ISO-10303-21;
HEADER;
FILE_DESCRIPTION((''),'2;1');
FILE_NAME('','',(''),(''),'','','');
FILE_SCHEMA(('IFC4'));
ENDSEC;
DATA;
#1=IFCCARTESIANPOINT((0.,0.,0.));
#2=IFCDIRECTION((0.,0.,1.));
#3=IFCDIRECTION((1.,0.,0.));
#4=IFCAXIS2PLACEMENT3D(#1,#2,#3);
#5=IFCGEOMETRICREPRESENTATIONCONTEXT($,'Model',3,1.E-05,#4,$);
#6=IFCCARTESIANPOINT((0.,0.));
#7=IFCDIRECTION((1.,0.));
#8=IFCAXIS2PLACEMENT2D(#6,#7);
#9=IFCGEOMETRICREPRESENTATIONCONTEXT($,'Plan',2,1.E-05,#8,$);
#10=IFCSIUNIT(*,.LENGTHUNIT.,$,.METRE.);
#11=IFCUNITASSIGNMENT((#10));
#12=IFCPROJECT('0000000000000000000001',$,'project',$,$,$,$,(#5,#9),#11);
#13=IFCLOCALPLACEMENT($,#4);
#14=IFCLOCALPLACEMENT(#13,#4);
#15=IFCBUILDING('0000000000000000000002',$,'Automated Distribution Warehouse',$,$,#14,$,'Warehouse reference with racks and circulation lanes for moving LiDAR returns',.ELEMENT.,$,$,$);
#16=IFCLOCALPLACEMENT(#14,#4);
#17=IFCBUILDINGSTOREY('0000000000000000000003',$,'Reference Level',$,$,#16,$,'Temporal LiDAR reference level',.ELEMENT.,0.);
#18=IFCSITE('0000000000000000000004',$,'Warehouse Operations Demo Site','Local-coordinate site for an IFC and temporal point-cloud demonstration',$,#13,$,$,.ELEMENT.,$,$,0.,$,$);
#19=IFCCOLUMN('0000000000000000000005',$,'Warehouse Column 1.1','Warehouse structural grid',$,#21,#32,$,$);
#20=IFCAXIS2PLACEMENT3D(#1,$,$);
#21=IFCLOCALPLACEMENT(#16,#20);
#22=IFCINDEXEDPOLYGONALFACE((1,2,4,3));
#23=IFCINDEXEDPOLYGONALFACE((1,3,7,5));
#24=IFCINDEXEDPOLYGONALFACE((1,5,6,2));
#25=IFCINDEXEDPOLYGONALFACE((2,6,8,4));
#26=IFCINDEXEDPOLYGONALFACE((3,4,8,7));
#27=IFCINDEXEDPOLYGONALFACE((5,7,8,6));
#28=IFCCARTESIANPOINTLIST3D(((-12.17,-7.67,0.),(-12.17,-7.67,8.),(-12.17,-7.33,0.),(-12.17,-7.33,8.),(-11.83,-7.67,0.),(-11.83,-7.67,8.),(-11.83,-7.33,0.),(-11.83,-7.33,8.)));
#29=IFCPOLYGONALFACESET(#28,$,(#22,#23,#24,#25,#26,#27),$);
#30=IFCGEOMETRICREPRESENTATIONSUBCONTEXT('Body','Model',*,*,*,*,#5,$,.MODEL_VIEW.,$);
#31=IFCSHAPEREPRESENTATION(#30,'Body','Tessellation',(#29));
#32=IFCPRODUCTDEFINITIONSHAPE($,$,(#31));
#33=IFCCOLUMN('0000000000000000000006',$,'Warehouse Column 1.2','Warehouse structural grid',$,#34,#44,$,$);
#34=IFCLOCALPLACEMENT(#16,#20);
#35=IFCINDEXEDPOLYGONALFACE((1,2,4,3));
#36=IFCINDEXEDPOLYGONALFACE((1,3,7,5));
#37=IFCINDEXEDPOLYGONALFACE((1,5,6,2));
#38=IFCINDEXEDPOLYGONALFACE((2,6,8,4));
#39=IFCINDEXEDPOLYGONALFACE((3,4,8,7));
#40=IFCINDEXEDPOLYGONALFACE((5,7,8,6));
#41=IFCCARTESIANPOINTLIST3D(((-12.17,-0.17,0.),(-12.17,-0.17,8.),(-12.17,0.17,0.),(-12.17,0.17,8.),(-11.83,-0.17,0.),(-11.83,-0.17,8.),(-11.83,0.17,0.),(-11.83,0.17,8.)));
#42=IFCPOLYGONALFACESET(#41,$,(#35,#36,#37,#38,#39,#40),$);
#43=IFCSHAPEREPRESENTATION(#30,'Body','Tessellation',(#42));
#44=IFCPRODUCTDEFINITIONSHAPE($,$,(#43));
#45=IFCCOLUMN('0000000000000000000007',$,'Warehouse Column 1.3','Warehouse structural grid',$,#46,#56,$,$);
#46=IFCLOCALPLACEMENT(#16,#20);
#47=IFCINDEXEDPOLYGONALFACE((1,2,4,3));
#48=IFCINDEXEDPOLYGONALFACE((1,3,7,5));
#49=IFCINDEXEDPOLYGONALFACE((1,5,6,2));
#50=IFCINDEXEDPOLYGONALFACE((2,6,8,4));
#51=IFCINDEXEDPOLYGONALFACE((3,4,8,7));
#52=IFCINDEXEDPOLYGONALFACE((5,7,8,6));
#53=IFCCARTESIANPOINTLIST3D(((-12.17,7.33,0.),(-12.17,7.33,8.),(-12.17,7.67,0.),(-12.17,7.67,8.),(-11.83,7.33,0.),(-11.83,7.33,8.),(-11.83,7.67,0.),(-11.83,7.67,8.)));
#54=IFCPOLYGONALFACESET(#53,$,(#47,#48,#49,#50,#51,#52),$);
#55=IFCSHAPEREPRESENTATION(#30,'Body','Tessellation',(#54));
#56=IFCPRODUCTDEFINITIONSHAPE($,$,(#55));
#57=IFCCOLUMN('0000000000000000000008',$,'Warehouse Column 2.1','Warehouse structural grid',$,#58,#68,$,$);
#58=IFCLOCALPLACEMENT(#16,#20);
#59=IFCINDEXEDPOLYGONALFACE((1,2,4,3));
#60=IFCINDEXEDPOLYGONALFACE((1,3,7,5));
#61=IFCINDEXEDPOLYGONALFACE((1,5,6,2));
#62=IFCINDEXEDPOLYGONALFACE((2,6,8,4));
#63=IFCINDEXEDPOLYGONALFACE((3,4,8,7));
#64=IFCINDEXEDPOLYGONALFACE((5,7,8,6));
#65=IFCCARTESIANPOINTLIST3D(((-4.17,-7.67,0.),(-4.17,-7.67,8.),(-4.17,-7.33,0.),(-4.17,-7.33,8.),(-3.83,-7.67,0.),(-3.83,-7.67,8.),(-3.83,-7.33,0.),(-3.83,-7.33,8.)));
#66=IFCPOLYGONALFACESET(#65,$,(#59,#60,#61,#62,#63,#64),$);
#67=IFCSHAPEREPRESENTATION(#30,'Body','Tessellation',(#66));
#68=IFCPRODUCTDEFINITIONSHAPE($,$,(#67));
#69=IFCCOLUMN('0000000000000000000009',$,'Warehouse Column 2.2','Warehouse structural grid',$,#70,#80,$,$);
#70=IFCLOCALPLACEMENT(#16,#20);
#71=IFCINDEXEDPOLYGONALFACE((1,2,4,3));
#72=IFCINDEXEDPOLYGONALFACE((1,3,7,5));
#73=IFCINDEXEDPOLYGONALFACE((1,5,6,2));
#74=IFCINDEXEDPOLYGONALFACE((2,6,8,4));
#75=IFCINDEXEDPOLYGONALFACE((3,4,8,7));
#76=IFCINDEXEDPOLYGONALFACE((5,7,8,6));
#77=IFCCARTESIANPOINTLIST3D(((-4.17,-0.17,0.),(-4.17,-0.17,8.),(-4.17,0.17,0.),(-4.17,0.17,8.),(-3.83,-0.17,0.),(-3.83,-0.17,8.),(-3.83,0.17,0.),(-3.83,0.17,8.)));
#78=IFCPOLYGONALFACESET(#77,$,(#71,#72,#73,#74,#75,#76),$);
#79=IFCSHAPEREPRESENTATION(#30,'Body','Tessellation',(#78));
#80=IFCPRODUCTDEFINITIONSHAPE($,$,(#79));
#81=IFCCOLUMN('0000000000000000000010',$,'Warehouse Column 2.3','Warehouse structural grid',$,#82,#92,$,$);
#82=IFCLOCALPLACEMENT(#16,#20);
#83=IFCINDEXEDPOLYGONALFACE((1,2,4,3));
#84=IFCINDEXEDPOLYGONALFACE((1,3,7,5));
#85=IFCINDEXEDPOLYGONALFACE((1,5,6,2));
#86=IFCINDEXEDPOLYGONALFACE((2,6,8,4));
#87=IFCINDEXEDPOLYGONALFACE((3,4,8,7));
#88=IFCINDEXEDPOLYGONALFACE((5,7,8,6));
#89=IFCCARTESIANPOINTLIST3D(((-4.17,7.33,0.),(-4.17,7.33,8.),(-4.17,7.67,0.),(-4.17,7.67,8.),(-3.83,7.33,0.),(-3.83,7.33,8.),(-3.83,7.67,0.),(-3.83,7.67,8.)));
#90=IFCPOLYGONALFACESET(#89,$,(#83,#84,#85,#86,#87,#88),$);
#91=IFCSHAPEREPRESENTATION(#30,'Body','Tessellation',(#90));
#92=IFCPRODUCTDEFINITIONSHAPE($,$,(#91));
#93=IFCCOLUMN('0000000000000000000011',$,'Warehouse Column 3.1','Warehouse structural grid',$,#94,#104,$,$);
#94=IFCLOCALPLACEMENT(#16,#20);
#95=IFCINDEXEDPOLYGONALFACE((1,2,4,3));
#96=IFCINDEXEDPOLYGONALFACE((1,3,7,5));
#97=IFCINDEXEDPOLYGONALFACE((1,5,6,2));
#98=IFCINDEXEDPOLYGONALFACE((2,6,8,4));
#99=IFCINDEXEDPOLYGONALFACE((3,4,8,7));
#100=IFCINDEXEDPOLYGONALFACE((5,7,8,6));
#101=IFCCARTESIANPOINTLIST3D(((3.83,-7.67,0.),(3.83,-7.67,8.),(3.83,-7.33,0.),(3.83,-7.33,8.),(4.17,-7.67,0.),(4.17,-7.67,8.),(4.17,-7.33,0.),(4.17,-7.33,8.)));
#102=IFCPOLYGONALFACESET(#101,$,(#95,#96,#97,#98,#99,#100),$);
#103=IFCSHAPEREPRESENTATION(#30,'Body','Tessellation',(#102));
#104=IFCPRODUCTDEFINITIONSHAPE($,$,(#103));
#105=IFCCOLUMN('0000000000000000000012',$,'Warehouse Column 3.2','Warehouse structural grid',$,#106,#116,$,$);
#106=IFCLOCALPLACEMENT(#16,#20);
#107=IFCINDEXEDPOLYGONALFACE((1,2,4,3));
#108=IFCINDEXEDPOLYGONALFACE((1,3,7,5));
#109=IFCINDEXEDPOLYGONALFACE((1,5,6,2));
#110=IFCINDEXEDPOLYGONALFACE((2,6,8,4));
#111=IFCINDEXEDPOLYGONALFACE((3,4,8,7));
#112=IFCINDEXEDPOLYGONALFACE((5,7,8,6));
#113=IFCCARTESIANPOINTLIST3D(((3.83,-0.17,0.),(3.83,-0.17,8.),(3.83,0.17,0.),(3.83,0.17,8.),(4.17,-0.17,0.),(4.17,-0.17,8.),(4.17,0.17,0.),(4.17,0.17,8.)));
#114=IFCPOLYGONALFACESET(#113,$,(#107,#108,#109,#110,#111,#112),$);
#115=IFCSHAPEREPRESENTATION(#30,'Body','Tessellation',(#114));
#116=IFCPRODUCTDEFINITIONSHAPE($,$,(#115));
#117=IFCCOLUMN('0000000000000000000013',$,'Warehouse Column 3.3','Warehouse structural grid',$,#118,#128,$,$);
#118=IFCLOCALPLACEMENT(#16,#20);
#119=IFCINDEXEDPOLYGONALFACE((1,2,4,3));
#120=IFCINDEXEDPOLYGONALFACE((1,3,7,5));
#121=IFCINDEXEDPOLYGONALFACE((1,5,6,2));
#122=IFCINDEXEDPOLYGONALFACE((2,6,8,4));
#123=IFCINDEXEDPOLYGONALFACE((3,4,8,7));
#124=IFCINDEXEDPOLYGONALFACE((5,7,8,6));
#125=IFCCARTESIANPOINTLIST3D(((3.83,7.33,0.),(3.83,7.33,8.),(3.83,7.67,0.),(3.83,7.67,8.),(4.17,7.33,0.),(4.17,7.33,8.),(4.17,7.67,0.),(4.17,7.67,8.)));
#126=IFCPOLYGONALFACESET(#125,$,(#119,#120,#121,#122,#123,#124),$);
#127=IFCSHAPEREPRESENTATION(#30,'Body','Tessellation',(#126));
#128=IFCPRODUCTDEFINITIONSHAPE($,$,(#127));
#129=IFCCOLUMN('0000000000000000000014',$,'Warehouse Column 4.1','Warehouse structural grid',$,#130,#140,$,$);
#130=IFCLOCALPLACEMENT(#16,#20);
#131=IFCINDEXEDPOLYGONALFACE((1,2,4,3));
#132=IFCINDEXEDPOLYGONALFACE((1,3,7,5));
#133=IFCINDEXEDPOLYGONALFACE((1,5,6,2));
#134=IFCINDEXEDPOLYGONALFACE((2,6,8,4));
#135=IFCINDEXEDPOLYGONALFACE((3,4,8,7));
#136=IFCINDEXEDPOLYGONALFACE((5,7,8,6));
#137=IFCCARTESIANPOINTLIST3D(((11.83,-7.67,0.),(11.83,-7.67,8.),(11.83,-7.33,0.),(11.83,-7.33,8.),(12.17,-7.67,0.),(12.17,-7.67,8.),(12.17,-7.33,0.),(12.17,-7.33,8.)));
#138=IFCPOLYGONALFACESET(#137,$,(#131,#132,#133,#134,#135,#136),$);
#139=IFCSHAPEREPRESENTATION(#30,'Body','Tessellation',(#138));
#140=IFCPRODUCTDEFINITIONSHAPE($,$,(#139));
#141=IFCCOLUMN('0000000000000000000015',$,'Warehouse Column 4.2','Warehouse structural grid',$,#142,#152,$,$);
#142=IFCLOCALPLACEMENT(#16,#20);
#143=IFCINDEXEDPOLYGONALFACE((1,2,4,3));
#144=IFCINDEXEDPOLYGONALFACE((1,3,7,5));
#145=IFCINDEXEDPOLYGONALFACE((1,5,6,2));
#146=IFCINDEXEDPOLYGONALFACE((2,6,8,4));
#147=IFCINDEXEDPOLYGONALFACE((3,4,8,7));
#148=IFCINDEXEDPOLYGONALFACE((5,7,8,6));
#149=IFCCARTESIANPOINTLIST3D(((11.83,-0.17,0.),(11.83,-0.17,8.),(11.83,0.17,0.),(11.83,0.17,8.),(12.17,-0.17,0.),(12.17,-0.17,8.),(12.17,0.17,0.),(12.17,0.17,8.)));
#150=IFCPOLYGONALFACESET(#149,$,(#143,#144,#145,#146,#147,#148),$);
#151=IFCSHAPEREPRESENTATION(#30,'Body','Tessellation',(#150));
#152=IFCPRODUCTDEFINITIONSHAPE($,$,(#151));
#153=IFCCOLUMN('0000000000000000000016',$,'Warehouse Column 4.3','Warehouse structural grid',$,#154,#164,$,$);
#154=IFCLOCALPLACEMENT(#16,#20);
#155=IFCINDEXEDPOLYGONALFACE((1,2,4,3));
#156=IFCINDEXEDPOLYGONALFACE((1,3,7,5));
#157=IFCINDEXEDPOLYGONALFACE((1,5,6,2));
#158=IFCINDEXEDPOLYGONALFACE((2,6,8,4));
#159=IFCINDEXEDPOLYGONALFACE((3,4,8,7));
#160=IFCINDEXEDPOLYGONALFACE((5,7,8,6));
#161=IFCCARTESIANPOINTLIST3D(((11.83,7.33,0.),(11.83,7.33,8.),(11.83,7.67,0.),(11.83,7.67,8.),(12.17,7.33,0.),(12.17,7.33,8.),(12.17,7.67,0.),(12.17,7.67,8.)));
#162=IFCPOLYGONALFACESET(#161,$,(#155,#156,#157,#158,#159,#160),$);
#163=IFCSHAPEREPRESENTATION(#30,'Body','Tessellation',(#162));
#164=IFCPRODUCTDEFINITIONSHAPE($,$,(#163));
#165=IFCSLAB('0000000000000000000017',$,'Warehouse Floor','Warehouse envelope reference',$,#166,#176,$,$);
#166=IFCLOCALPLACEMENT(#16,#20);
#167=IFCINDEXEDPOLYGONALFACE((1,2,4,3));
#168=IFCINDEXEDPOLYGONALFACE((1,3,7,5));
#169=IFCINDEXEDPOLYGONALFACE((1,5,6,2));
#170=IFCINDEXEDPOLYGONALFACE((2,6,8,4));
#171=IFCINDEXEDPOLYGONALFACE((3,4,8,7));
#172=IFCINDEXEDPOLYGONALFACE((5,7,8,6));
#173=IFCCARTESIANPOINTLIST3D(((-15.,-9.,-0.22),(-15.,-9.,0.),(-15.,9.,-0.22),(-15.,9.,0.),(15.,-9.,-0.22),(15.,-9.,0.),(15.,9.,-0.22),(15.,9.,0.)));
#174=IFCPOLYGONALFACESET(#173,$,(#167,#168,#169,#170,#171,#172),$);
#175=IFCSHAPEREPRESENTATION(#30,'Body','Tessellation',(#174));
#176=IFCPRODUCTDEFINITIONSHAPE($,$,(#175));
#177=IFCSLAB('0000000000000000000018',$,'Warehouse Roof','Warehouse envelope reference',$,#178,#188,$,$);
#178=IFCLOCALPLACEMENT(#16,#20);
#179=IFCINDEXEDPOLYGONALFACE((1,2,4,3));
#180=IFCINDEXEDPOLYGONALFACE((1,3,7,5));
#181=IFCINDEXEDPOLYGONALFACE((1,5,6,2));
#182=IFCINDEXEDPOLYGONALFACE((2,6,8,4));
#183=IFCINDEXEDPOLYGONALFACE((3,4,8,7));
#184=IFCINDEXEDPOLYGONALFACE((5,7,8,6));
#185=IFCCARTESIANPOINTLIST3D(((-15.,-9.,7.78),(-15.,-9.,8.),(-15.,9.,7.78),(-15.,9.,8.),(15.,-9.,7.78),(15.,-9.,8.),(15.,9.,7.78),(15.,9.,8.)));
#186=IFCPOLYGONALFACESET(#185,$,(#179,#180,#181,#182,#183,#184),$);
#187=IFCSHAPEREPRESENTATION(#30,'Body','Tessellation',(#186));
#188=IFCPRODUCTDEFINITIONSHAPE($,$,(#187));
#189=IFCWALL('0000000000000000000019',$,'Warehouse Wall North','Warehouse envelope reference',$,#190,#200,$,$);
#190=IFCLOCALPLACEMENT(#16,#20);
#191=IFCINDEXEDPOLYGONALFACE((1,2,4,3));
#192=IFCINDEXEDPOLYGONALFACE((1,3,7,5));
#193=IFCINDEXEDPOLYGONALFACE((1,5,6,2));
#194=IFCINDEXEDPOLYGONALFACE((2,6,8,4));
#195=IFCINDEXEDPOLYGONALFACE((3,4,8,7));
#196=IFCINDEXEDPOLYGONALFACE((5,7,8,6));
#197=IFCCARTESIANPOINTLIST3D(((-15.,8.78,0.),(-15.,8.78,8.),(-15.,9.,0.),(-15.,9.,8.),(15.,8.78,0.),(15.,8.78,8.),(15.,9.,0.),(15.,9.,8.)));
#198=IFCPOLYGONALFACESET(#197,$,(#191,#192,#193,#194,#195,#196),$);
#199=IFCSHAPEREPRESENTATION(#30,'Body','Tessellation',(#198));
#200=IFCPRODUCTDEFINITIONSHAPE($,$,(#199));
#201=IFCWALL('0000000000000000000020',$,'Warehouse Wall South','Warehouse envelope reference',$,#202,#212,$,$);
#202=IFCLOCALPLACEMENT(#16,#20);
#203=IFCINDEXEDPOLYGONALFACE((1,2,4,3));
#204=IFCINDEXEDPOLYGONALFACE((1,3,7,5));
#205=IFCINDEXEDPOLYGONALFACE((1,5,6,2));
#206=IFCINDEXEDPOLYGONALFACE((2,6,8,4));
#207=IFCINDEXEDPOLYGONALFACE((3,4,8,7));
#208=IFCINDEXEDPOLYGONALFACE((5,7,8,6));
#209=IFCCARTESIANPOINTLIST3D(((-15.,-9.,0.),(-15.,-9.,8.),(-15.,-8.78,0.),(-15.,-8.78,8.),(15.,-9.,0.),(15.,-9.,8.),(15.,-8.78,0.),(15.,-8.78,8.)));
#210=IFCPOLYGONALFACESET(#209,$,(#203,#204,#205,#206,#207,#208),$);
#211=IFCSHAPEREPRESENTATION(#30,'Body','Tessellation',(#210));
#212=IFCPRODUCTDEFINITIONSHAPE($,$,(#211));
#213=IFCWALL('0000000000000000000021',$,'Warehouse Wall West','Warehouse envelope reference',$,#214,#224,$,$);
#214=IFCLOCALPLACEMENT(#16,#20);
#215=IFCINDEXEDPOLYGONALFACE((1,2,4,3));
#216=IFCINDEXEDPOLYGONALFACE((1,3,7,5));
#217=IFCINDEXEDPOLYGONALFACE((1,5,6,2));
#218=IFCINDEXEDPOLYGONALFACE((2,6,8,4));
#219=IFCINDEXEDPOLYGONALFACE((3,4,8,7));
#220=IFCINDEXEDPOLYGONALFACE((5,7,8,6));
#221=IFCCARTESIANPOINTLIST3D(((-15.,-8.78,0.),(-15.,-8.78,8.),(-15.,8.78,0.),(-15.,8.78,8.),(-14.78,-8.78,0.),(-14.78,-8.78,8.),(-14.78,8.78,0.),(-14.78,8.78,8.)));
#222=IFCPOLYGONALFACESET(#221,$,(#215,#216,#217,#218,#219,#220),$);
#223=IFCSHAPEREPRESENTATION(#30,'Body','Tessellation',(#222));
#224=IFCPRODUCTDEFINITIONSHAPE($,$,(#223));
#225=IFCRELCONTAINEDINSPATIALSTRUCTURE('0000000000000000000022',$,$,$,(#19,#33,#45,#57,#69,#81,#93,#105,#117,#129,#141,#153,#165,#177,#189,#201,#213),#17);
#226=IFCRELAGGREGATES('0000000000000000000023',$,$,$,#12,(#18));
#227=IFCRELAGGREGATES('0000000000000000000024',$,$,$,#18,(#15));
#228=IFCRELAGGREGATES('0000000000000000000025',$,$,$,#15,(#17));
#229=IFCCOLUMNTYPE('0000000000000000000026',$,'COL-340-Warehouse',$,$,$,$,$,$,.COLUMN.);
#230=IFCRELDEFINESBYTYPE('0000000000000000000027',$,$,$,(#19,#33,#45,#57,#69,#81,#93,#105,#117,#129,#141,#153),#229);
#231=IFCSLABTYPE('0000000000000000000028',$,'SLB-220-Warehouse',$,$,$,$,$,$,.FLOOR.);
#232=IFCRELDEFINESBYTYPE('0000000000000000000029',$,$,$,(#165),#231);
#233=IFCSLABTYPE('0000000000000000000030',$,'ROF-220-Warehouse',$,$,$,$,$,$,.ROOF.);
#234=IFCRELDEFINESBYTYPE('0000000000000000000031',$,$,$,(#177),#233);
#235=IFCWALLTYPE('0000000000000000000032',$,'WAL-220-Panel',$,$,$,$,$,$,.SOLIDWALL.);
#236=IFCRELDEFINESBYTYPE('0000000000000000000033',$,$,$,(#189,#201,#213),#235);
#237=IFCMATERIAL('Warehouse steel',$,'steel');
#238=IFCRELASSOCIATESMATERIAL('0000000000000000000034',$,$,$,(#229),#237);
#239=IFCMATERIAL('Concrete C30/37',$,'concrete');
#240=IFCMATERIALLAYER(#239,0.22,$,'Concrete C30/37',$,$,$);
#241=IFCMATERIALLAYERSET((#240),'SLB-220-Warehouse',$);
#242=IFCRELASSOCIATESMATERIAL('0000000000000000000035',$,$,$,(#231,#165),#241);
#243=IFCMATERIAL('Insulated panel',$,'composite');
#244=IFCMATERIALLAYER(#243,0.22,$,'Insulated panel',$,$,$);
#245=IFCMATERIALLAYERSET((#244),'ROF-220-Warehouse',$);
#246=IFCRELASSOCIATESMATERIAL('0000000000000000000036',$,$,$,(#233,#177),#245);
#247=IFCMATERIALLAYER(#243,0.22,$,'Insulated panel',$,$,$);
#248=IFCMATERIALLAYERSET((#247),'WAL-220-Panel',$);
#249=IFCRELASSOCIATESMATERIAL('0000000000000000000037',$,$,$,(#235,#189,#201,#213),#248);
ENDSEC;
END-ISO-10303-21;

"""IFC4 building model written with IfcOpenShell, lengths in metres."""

from ifc_helpers import new_model, si_unit, frame, origin_with_axes, origin_2d_with_axis, place, context, subcontext, project, spatial, line, indexed_curve, outline, extrude, material, layer, layer_set, layer_usage, type_object, element, save


model = new_model("IFC4")

# Units and contexts
model_context = context("Model", 3, precision=1e-05, world=origin_with_axes())
plan_context = context("Plan", 2, precision=1e-05, world=origin_2d_with_axis())
body_context = subcontext(model_context, "Body", "Model", "MODEL_VIEW")
ifc_project = project(units=[si_unit("LENGTHUNIT", "METRE")], contexts=[model_context, plan_context])

# Site, building, storey
site_placement = place(None, origin_with_axes())
site = spatial("IfcSite", under=ifc_project, at=site_placement, Name="Warehouse Operations Demo Site", Description="Local-coordinate site for an IFC and temporal point-cloud demonstration", CompositionType="ELEMENT", RefElevation=0.0)
building_placement = place(site_placement, origin_with_axes())
building = spatial("IfcBuilding", under=site, at=building_placement, Name="Automated Distribution Warehouse", LongName="Warehouse reference with racks and circulation lanes for moving LiDAR returns", CompositionType="ELEMENT")
storey_placement = place(building_placement, origin_with_axes())
storey = spatial("IfcBuildingStorey", under=building, at=storey_placement, Name="Reference Level", LongName="Temporal LiDAR reference level", CompositionType="ELEMENT", Elevation=0.0)

# Columns
ifc_material_1 = material(Name="Warehouse steel", Category="steel")
column_type = type_object("IfcColumnType", Name="COL-340-Warehouse", PredefinedType="COLUMN", material=ifc_material_1)
for number, where, z_axis, x_axis, name in (
    (1, (-12.17, -7.67, 0.0), (0.0, 0.0, 1.0), (1.0, 0.0, 0.0), "Warehouse Column 1.1"),
    (2, (-12.17, -0.17, 0.0), (0.0, 0.0, 1.0), (1.0, 0.0, 0.0), "Warehouse Column 1.2"),
    (3, (-12.17, 7.33, 0.0), (0.0, 0.0, 1.0), (1.0, 0.0, 0.0), "Warehouse Column 1.3"),
    (4, (-4.17, -7.67, 0.0), (0.0, 0.0, 1.0), (1.0, 0.0, 0.0), "Warehouse Column 2.1"),
    (5, (-4.17, -0.17, 0.0), (0.0, 0.0, 1.0), (1.0, 0.0, 0.0), "Warehouse Column 2.2"),
    (6, (-4.17, 7.33, 0.0), (0.0, 0.0, 1.0), (1.0, 0.0, 0.0), "Warehouse Column 2.3"),
    (7, (3.83, -7.67, 0.0), (0.0, 0.0, 1.0), (1.0, 0.0, 0.0), "Warehouse Column 3.1"),
    (8, (3.83, -0.17, 0.0), (0.0, 0.0, 1.0), (1.0, 0.0, 0.0), "Warehouse Column 3.2"),
    (9, (3.83, 7.33, 0.0), (0.0, 0.0, 1.0), (1.0, 0.0, 0.0), "Warehouse Column 3.3"),
    (10, (11.83, -7.67, 0.0), (0.0, 0.0, 1.0), (1.0, 0.0, 0.0), "Warehouse Column 4.1"),
    (11, (11.83, -0.17, 0.0), (0.0, 0.0, 1.0), (1.0, 0.0, 0.0), "Warehouse Column 4.2"),
    (12, (11.83, 7.33, 0.0), (0.0, 0.0, 1.0), (1.0, 0.0, 0.0), "Warehouse Column 4.3"),
):
    element("IfcColumn", number, at=place(storey_placement, frame(where, z_axis=z_axis, x_axis=x_axis)), inside=storey, type_object=column_type, Name=name, Description="Warehouse structural grid", context=body_context, shape_type="SweptSolid", body=[
        extrude(outline(indexed_curve([(0.0, 0.0), (0.34, 0.0), (0.34, 0.34), (0.0, 0.34)], segments=[line(1, 2, 3, 4, 1)])), origin_with_axes(), (0.0, 0.0, 1.0), 8.0),
    ])

# Slabs
ifc_material_2 = material(Name="Concrete C30/37", Category="concrete")
ifc_layer_1 = layer(ifc_material_2, 0.22, Name="Concrete C30/37")
ifc_layer_set_1 = layer_set([ifc_layer_1], Name="SLB-220-Warehouse")
ifc_layer_usage_1 = layer_usage(ifc_layer_set_1, "AXIS3", "POSITIVE", 0.0)
slab_type_1 = type_object("IfcSlabType", Name="SLB-220-Warehouse", PredefinedType="FLOOR", material=ifc_layer_set_1)
slab_1_placement = place(storey_placement, frame((-15.0, -9.0, -0.22), z_axis=(0.0, 0.0, 1.0), x_axis=(1.0, 0.0, 0.0)))
element("IfcSlab", 13, at=slab_1_placement, inside=storey, type_object=slab_type_1, material=ifc_layer_usage_1, Name="Warehouse Floor", Description="Warehouse envelope reference", context=body_context, shape_type="SweptSolid", body=[
    extrude(outline(indexed_curve([(0.0, 0.0), (30.0, 0.0), (30.0, 18.0), (0.0, 18.0)], segments=[line(1, 2, 3, 4, 1)])), origin_with_axes(), (0.0, 0.0, 1.0), 0.22),
])
ifc_material_3 = material(Name="Insulated panel", Category="composite")
ifc_layer_2 = layer(ifc_material_3, 0.22, Name="Insulated panel")
ifc_layer_set_2 = layer_set([ifc_layer_2], Name="ROF-220-Warehouse")
ifc_layer_usage_2 = layer_usage(ifc_layer_set_2, "AXIS3", "POSITIVE", 0.0)
slab_type_2 = type_object("IfcSlabType", Name="ROF-220-Warehouse", PredefinedType="ROOF", material=ifc_layer_set_2)
slab_2_placement = place(storey_placement, frame((-15.0, -9.0, 7.78), z_axis=(0.0, 0.0, 1.0), x_axis=(1.0, 0.0, 0.0)))
element("IfcSlab", 14, at=slab_2_placement, inside=storey, type_object=slab_type_2, material=ifc_layer_usage_2, Name="Warehouse Roof", Description="Warehouse envelope reference", context=body_context, shape_type="SweptSolid", body=[
    extrude(outline(indexed_curve([(0.0, 0.0), (30.0, 0.0), (30.0, 18.0), (0.0, 18.0)], segments=[line(1, 2, 3, 4, 1)])), origin_with_axes(), (0.0, 0.0, 1.0), 0.22),
])

# Walls
ifc_layer_3 = layer(ifc_material_3, 0.22, Name="Insulated panel")
ifc_layer_set_3 = layer_set([ifc_layer_3], Name="WAL-220-Panel")
ifc_layer_usage_3 = layer_usage(ifc_layer_set_3, "AXIS2", "POSITIVE", 0.0)
wall_type = type_object("IfcWallType", Name="WAL-220-Panel", PredefinedType="SOLIDWALL", material=ifc_layer_set_3)
wall_1_placement = place(storey_placement, frame((-15.0, 8.78, 0.0), z_axis=(0.0, 0.0, 1.0), x_axis=(1.0, 0.0, 0.0)))
element("IfcWall", 15, at=wall_1_placement, inside=storey, type_object=wall_type, material=ifc_layer_usage_3, Name="Warehouse Wall North", Description="Warehouse envelope reference", context=body_context, shape_type="SweptSolid", body=[
    extrude(outline(indexed_curve([(0.0, 0.0), (30.0, 0.0), (30.0, 0.22), (0.0, 0.22)], segments=[line(1, 2, 3, 4, 1)])), origin_with_axes(), (0.0, 0.0, 1.0), 8.0),
])
ifc_layer_usage_4 = layer_usage(ifc_layer_set_3, "AXIS2", "POSITIVE", 0.0)
wall_2_placement = place(storey_placement, frame((-15.0, -9.0, 0.0), z_axis=(0.0, 0.0, 1.0), x_axis=(1.0, 0.0, 0.0)))
element("IfcWall", 16, at=wall_2_placement, inside=storey, type_object=wall_type, material=ifc_layer_usage_4, Name="Warehouse Wall South", Description="Warehouse envelope reference", context=body_context, shape_type="SweptSolid", body=[
    extrude(outline(indexed_curve([(0.0, 0.0), (30.0, 0.0), (30.0, 0.22), (0.0, 0.22)], segments=[line(1, 2, 3, 4, 1)])), origin_with_axes(), (0.0, 0.0, 1.0), 8.0),
])
ifc_layer_usage_5 = layer_usage(ifc_layer_set_3, "AXIS2", "POSITIVE", 0.0)
wall_3_placement = place(storey_placement, frame((-15.0, -8.78, 0.0), z_axis=(0.0, 0.0, 1.0), x_axis=(1.0, 0.0, 0.0)))
element("IfcWall", 17, at=wall_3_placement, inside=storey, type_object=wall_type, material=ifc_layer_usage_5, Name="Warehouse Wall West", Description="Warehouse envelope reference", context=body_context, shape_type="SweptSolid", body=[
    extrude(outline(indexed_curve([(0.0, 0.0), (0.22, 0.0), (0.22, 17.56), (0.0, 17.56)], segments=[line(1, 2, 3, 4, 1)])), origin_with_axes(), (0.0, 0.0, 1.0), 8.0),
])

save(model, "model.ifc")
